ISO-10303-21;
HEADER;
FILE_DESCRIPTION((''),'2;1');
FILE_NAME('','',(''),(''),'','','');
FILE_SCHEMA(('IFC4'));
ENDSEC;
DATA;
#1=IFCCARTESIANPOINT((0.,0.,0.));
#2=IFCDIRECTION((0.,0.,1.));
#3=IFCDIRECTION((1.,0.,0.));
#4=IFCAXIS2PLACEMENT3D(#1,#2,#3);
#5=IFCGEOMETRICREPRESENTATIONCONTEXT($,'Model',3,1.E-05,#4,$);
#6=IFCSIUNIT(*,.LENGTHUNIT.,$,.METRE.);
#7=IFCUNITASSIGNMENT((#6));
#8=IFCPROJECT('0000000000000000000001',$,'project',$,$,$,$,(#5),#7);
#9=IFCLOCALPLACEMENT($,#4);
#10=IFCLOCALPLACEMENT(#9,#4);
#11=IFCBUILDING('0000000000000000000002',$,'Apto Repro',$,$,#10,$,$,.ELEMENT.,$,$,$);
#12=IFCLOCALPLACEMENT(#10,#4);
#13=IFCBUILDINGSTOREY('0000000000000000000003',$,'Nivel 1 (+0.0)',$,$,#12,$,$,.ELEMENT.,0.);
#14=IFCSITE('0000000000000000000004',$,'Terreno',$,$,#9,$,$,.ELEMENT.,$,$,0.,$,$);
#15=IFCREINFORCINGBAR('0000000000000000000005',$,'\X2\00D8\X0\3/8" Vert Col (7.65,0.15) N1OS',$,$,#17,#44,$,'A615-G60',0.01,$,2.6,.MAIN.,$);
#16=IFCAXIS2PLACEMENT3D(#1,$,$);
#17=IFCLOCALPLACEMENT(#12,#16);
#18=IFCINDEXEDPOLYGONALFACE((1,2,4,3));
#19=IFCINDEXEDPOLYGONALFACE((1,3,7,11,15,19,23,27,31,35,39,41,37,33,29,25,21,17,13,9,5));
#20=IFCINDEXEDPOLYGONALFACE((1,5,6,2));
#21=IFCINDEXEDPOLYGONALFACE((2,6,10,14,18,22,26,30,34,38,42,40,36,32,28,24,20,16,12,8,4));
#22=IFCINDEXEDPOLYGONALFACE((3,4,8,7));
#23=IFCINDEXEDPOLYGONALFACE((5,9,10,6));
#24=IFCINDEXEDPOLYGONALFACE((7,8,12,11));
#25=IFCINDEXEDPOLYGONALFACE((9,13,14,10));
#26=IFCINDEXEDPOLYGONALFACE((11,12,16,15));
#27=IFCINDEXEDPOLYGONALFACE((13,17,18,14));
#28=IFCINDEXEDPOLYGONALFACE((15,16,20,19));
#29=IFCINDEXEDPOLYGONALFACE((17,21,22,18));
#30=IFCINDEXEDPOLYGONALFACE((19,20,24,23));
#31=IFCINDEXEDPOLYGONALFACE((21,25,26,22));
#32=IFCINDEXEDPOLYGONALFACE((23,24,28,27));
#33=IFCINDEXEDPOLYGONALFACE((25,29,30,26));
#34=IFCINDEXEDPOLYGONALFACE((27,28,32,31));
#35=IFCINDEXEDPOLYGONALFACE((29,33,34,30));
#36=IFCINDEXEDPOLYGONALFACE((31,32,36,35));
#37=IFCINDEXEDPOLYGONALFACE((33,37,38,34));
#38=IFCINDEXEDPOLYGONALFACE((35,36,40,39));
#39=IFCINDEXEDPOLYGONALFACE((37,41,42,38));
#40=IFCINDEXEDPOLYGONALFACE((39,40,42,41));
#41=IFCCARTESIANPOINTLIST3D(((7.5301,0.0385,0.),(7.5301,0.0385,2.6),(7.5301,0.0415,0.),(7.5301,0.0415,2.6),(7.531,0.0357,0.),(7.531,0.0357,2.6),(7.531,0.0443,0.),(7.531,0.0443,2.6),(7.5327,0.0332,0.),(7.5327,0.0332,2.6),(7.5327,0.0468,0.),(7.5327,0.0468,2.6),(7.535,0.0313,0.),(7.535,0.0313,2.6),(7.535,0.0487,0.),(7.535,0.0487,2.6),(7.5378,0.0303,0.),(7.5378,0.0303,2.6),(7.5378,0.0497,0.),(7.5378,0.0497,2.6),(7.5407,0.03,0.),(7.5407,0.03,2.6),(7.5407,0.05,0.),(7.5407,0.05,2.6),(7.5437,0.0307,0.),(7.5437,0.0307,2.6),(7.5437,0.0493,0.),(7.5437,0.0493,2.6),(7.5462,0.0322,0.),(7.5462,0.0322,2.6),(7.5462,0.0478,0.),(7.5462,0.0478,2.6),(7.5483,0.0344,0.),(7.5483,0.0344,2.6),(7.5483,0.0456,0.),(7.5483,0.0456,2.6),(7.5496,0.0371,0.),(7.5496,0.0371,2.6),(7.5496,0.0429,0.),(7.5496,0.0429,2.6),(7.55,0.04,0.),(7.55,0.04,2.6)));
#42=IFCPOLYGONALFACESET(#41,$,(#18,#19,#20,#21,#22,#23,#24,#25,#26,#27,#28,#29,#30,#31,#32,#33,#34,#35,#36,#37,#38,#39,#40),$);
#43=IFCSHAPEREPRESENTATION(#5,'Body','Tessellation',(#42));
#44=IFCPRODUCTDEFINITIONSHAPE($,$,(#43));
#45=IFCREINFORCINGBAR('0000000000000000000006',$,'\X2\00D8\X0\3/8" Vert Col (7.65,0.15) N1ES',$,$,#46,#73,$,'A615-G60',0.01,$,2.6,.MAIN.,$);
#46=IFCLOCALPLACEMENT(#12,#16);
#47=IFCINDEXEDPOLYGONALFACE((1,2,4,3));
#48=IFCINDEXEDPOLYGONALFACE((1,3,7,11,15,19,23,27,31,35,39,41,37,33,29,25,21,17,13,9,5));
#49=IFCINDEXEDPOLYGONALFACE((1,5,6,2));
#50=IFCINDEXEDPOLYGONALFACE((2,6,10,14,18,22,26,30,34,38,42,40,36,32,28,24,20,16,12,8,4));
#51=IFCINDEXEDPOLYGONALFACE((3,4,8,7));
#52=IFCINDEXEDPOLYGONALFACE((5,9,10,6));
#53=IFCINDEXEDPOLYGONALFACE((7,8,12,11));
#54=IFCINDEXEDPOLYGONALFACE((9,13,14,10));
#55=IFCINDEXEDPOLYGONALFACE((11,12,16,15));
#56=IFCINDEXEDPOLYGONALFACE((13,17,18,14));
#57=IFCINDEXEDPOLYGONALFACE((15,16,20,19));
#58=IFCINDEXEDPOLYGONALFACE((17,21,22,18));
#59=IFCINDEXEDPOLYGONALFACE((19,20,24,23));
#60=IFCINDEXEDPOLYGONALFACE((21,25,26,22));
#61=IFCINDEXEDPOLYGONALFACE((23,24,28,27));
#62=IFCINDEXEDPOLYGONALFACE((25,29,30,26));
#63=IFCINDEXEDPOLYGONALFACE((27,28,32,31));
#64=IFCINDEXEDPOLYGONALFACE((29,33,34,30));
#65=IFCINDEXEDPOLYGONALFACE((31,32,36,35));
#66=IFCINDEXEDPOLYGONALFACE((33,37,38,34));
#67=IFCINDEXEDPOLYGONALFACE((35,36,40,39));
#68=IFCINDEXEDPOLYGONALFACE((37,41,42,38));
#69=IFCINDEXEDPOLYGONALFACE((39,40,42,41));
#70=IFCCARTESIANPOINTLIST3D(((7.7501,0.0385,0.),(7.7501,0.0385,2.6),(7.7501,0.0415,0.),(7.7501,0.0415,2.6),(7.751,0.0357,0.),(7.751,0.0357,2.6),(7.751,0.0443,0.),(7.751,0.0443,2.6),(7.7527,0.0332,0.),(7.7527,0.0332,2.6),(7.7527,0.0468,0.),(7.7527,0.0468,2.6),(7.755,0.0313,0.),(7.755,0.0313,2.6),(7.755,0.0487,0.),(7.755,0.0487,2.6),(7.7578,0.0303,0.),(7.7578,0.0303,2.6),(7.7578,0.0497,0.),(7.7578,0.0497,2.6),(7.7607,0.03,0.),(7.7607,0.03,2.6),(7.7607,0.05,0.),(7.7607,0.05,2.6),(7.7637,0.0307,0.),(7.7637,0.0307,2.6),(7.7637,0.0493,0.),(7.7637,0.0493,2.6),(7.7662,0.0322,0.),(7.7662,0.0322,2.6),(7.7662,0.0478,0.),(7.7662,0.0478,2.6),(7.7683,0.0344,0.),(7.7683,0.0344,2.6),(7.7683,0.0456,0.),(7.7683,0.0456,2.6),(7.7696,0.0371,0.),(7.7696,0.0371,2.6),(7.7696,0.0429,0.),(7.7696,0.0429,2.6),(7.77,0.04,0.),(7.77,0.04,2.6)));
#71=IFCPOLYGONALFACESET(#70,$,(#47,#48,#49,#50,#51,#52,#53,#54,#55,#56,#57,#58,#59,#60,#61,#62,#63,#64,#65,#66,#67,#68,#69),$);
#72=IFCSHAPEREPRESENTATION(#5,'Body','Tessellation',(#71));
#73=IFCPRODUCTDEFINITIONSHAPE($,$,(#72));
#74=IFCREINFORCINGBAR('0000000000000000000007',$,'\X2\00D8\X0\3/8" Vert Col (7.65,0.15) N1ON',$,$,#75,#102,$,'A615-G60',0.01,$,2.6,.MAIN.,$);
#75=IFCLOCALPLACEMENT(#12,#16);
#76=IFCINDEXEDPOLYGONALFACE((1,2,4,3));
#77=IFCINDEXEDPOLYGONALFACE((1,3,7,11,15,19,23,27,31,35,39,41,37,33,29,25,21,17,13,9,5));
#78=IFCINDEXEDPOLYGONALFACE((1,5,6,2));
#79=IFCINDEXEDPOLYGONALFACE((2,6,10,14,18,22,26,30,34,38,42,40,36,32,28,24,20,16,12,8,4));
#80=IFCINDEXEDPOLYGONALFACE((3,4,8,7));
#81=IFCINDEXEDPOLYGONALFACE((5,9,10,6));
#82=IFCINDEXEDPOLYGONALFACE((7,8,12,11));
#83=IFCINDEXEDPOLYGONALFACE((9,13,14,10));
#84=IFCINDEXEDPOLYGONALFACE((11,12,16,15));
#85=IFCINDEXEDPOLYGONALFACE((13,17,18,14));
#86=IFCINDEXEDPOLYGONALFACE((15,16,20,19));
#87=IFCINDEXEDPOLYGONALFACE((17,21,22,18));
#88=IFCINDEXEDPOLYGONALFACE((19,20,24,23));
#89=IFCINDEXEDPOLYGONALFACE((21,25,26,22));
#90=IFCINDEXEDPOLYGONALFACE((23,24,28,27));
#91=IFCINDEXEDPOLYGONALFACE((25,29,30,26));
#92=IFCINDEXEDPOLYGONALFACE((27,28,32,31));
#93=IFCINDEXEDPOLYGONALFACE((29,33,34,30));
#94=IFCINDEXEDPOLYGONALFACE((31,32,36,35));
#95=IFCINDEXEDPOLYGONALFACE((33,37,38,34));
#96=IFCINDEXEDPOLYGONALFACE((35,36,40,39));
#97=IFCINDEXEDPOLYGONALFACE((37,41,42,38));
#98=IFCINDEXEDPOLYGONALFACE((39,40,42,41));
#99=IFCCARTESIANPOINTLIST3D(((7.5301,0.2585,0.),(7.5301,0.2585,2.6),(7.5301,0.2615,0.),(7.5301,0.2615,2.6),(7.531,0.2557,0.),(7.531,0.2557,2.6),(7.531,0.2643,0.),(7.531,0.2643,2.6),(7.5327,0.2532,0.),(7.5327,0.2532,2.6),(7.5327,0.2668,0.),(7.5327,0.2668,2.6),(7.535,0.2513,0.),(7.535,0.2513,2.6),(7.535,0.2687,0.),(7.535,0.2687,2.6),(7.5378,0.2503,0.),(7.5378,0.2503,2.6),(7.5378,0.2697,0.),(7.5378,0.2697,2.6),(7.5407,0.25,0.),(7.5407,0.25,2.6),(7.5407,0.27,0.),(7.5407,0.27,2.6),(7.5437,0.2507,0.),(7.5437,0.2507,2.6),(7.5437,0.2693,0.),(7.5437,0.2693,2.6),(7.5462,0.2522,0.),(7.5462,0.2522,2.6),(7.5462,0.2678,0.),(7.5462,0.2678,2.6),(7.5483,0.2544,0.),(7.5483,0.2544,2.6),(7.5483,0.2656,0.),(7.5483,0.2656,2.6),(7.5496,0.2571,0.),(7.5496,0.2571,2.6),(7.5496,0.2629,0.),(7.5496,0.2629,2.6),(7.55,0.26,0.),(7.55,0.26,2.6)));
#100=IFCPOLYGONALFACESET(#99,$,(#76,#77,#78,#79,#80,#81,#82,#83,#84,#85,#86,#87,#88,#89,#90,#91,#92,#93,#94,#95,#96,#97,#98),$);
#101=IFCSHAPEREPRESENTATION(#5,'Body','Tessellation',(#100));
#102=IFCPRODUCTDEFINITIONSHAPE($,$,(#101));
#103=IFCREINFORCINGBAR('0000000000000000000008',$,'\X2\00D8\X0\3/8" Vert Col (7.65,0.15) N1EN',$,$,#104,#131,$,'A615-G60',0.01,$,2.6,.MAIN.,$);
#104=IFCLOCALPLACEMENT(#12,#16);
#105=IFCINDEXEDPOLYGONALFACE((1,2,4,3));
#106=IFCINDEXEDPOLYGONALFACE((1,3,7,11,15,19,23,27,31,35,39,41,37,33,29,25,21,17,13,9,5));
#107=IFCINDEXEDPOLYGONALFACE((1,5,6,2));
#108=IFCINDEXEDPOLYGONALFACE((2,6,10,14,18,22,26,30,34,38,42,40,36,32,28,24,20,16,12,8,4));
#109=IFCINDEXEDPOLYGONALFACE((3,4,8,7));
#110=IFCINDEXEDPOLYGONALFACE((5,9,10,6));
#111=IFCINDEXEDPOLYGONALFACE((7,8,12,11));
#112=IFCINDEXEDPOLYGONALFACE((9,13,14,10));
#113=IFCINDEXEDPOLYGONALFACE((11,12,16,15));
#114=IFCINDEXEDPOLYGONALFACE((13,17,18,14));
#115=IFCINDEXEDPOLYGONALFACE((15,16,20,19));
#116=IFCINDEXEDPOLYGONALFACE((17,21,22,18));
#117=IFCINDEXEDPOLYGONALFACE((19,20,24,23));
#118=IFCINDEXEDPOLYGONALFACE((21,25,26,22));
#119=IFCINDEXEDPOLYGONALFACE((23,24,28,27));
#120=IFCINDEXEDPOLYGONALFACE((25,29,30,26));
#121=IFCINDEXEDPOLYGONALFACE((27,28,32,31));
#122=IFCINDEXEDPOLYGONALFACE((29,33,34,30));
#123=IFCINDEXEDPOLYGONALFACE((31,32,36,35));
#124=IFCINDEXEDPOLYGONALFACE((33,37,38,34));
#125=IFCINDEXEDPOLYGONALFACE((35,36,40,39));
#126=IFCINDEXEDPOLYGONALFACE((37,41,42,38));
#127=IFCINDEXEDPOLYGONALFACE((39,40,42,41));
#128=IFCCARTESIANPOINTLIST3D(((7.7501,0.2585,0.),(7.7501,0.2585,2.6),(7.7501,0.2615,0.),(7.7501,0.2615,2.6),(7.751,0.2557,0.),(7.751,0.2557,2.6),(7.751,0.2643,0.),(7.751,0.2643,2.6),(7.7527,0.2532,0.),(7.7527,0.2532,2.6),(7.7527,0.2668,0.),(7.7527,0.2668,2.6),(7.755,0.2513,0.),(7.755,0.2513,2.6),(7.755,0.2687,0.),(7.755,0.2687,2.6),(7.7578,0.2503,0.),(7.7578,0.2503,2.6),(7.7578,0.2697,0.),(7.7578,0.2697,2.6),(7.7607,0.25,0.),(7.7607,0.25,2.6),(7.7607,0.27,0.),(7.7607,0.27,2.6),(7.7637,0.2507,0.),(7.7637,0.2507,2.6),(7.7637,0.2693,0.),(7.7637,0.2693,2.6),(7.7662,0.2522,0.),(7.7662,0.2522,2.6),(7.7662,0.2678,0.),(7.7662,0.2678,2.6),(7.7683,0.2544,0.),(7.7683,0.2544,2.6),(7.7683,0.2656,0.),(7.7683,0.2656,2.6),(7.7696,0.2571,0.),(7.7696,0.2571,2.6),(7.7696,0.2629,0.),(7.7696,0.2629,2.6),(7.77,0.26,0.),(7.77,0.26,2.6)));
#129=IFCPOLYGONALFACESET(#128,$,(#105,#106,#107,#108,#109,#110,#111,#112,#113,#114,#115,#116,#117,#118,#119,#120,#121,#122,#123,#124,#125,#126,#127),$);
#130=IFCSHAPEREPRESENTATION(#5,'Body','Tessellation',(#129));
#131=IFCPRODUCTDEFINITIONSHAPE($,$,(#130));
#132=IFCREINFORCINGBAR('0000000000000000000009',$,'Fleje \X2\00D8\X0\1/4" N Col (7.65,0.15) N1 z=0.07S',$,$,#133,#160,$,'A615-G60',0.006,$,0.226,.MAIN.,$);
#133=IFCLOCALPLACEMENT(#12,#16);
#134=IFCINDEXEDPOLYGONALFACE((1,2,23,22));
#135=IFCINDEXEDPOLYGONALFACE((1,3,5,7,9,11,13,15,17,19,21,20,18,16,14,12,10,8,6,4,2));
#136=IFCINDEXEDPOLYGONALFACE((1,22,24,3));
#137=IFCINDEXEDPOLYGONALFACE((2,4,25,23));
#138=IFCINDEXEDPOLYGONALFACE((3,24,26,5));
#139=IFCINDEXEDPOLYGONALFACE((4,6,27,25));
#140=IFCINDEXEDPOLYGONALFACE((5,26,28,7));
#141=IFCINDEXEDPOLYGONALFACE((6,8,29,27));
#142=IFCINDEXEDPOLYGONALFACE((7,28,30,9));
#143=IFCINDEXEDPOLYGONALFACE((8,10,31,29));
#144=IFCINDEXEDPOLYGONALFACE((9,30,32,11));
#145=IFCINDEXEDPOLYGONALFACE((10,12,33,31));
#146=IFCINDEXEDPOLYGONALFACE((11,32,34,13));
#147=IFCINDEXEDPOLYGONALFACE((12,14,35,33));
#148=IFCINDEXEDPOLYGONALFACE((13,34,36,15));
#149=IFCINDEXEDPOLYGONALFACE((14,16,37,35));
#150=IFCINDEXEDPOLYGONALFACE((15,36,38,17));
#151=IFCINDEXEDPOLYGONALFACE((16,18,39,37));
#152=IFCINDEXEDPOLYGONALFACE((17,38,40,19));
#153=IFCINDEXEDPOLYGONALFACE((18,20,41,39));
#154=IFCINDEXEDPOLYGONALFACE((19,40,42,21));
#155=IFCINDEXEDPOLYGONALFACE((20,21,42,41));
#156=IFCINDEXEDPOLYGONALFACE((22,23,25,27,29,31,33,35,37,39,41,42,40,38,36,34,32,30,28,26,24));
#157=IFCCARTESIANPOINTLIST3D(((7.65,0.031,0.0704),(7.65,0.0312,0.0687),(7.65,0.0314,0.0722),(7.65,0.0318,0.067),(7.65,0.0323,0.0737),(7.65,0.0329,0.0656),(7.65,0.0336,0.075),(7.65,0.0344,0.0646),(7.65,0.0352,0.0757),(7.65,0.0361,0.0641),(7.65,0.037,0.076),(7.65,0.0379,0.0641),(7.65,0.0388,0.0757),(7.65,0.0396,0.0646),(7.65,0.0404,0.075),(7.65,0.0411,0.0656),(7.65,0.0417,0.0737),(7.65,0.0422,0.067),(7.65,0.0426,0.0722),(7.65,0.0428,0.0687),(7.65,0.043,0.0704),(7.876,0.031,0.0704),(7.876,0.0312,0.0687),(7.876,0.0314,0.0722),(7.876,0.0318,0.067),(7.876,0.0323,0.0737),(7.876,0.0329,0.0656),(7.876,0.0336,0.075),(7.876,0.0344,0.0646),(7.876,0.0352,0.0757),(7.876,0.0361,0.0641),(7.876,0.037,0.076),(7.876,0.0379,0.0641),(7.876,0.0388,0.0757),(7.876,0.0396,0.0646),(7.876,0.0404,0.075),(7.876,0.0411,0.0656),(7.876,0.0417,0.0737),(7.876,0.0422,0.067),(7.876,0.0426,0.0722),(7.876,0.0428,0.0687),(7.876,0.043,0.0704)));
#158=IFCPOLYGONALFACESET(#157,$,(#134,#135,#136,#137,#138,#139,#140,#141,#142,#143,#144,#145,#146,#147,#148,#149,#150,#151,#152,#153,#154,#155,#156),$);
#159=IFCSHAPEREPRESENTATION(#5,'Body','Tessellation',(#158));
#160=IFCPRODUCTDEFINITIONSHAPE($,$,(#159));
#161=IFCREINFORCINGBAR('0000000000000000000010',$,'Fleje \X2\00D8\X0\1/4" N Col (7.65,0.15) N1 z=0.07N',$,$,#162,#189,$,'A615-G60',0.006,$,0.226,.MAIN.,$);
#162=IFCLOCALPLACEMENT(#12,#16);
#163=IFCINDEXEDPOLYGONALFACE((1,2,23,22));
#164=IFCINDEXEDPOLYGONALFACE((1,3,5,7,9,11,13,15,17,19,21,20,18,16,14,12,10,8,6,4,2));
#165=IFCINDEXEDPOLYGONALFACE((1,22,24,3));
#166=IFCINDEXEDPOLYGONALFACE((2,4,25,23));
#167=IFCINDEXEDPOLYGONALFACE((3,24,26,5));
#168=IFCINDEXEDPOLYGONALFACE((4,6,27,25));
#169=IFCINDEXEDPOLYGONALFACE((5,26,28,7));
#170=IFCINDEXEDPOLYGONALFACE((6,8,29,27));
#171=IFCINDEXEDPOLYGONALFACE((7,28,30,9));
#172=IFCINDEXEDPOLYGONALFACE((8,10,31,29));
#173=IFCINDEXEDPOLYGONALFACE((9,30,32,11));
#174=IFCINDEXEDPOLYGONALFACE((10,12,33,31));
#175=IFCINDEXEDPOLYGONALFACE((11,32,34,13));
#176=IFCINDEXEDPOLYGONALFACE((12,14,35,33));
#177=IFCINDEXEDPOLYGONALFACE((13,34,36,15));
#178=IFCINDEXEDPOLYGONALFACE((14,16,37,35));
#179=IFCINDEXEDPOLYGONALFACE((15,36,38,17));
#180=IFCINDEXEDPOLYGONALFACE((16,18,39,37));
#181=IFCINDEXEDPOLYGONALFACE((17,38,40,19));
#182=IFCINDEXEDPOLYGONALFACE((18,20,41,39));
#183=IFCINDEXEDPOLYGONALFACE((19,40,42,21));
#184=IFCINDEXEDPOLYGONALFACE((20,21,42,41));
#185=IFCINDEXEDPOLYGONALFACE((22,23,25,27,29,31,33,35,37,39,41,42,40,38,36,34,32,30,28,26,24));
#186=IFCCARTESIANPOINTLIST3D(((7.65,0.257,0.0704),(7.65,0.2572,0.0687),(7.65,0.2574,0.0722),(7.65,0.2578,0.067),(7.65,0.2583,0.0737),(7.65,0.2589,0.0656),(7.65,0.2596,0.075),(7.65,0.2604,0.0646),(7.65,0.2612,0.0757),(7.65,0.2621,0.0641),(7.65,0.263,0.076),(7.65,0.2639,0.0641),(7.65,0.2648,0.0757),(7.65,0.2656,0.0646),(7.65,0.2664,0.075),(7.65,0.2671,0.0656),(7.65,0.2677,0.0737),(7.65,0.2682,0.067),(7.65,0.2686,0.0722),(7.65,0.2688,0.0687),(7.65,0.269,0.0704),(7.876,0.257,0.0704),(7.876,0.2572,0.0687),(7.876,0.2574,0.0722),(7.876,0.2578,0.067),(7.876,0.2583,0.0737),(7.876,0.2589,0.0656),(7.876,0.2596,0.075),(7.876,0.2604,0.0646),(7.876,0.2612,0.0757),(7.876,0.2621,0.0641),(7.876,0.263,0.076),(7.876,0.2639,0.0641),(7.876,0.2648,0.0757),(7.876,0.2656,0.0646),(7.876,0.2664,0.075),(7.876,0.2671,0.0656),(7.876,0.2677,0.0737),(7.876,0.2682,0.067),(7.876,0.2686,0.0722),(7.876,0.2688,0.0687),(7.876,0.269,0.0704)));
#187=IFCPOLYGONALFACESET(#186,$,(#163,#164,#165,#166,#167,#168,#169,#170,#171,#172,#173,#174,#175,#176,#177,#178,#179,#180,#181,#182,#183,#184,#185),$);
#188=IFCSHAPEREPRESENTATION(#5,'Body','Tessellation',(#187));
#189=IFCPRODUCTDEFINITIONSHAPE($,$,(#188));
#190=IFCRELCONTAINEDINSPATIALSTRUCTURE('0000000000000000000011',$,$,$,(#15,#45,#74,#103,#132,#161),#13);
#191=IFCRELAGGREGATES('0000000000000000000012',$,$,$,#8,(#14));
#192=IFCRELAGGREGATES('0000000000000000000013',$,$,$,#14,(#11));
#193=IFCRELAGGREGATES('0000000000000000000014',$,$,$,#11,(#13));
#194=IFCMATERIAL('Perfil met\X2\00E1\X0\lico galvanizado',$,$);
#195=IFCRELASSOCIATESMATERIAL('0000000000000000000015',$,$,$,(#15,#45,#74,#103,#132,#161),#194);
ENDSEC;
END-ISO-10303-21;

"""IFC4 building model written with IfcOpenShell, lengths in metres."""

from ifc_helpers import new_model, si_unit, frame, origin_with_axes, origin_2d_with_axis, place, context, project, spatial, circle, extrude, material, element, save


model = new_model("IFC4")

# Units and contexts
model_context = context("Model", 3, precision=1e-05, world=origin_with_axes())
ifc_project = project(units=[si_unit("LENGTHUNIT", "METRE")], contexts=[model_context])

# Site, building, storey
site_placement = place(None, origin_with_axes())
site = spatial("IfcSite", under=ifc_project, at=site_placement, Name="Terreno", CompositionType="ELEMENT", RefElevation=0.0)
building_placement = place(site_placement, origin_with_axes())
building = spatial("IfcBuilding", under=site, at=building_placement, Name="Apto Repro", CompositionType="ELEMENT")
storey_placement = place(building_placement, origin_with_axes())
storey = spatial("IfcBuildingStorey", under=building, at=storey_placement, Name="Nivel 1 (+0.0)", CompositionType="ELEMENT", Elevation=0.0)

# Reinforcing bars
ifc_material = material(Name="Perfil metálico galvanizado")
reinforcing_bar_1_placement = place(storey_placement, origin_with_axes())
element("IfcReinforcingBar", 1, at=reinforcing_bar_1_placement, inside=storey, material=ifc_material, Name="Ø3/8\" Vert Col (7.65,0.15) N1OS", SteelGrade="A615-G60", BarLength=2.6, NominalDiameter=0.01, PredefinedType="MAIN", context=model_context, shape_type="SweptSolid", body=[
    extrude(circle(Radius=0.01, at=origin_2d_with_axis()), frame((7.54, 0.04, 0.0), z_axis=(0.0, 0.0, 1.0), x_axis=(1.0, 0.0, 0.0)), (0.0, 0.0, 1.0), 2.6),
])
reinforcing_bar_2_placement = place(storey_placement, origin_with_axes())
element("IfcReinforcingBar", 2, at=reinforcing_bar_2_placement, inside=storey, material=ifc_material, Name="Ø3/8\" Vert Col (7.65,0.15) N1ES", SteelGrade="A615-G60", BarLength=2.6, NominalDiameter=0.01, PredefinedType="MAIN", context=model_context, shape_type="SweptSolid", body=[
    extrude(circle(Radius=0.01, at=origin_2d_with_axis()), frame((7.76, 0.04, 0.0), z_axis=(0.0, 0.0, 1.0), x_axis=(1.0, 0.0, 0.0)), (0.0, 0.0, 1.0), 2.6),
])
reinforcing_bar_3_placement = place(storey_placement, origin_with_axes())
element("IfcReinforcingBar", 3, at=reinforcing_bar_3_placement, inside=storey, material=ifc_material, Name="Ø3/8\" Vert Col (7.65,0.15) N1ON", SteelGrade="A615-G60", BarLength=2.6, NominalDiameter=0.01, PredefinedType="MAIN", context=model_context, shape_type="SweptSolid", body=[
    extrude(circle(Radius=0.01, at=origin_2d_with_axis()), frame((7.54, 0.26, 0.0), z_axis=(0.0, 0.0, 1.0), x_axis=(1.0, 0.0, 0.0)), (0.0, 0.0, 1.0), 2.6),
])
reinforcing_bar_4_placement = place(storey_placement, origin_with_axes())
element("IfcReinforcingBar", 4, at=reinforcing_bar_4_placement, inside=storey, material=ifc_material, Name="Ø3/8\" Vert Col (7.65,0.15) N1EN", SteelGrade="A615-G60", BarLength=2.6, NominalDiameter=0.01, PredefinedType="MAIN", context=model_context, shape_type="SweptSolid", body=[
    extrude(circle(Radius=0.01, at=origin_2d_with_axis()), frame((7.76, 0.26, 0.0), z_axis=(0.0, 0.0, 1.0), x_axis=(1.0, 0.0, 0.0)), (0.0, 0.0, 1.0), 2.6),
])
reinforcing_bar_5_placement = place(storey_placement, origin_with_axes())
element("IfcReinforcingBar", 5, at=reinforcing_bar_5_placement, inside=storey, material=ifc_material, Name="Fleje Ø1/4\" N Col (7.65,0.15) N1 z=0.07S", SteelGrade="A615-G60", BarLength=0.226, NominalDiameter=0.006, PredefinedType="MAIN", context=model_context, shape_type="SweptSolid", body=[
    extrude(circle(Radius=0.006, at=origin_2d_with_axis()), frame((7.65, 0.037, 0.07), z_axis=(1.0, 0.0, 0.0), x_axis=(0.0, 0.0, 1.0)), (0.0, 0.0, 1.0), 0.226),
])
reinforcing_bar_6_placement = place(storey_placement, origin_with_axes())
element("IfcReinforcingBar", 6, at=reinforcing_bar_6_placement, inside=storey, material=ifc_material, Name="Fleje Ø1/4\" N Col (7.65,0.15) N1 z=0.07N", SteelGrade="A615-G60", BarLength=0.226, NominalDiameter=0.006, PredefinedType="MAIN", context=model_context, shape_type="SweptSolid", body=[
    extrude(circle(Radius=0.006, at=origin_2d_with_axis()), frame((7.65, 0.263, 0.07), z_axis=(1.0, 0.0, 0.0), x_axis=(0.0, 0.0, 1.0)), (0.0, 0.0, 1.0), 0.226),
])

save(model, "model.ifc")
